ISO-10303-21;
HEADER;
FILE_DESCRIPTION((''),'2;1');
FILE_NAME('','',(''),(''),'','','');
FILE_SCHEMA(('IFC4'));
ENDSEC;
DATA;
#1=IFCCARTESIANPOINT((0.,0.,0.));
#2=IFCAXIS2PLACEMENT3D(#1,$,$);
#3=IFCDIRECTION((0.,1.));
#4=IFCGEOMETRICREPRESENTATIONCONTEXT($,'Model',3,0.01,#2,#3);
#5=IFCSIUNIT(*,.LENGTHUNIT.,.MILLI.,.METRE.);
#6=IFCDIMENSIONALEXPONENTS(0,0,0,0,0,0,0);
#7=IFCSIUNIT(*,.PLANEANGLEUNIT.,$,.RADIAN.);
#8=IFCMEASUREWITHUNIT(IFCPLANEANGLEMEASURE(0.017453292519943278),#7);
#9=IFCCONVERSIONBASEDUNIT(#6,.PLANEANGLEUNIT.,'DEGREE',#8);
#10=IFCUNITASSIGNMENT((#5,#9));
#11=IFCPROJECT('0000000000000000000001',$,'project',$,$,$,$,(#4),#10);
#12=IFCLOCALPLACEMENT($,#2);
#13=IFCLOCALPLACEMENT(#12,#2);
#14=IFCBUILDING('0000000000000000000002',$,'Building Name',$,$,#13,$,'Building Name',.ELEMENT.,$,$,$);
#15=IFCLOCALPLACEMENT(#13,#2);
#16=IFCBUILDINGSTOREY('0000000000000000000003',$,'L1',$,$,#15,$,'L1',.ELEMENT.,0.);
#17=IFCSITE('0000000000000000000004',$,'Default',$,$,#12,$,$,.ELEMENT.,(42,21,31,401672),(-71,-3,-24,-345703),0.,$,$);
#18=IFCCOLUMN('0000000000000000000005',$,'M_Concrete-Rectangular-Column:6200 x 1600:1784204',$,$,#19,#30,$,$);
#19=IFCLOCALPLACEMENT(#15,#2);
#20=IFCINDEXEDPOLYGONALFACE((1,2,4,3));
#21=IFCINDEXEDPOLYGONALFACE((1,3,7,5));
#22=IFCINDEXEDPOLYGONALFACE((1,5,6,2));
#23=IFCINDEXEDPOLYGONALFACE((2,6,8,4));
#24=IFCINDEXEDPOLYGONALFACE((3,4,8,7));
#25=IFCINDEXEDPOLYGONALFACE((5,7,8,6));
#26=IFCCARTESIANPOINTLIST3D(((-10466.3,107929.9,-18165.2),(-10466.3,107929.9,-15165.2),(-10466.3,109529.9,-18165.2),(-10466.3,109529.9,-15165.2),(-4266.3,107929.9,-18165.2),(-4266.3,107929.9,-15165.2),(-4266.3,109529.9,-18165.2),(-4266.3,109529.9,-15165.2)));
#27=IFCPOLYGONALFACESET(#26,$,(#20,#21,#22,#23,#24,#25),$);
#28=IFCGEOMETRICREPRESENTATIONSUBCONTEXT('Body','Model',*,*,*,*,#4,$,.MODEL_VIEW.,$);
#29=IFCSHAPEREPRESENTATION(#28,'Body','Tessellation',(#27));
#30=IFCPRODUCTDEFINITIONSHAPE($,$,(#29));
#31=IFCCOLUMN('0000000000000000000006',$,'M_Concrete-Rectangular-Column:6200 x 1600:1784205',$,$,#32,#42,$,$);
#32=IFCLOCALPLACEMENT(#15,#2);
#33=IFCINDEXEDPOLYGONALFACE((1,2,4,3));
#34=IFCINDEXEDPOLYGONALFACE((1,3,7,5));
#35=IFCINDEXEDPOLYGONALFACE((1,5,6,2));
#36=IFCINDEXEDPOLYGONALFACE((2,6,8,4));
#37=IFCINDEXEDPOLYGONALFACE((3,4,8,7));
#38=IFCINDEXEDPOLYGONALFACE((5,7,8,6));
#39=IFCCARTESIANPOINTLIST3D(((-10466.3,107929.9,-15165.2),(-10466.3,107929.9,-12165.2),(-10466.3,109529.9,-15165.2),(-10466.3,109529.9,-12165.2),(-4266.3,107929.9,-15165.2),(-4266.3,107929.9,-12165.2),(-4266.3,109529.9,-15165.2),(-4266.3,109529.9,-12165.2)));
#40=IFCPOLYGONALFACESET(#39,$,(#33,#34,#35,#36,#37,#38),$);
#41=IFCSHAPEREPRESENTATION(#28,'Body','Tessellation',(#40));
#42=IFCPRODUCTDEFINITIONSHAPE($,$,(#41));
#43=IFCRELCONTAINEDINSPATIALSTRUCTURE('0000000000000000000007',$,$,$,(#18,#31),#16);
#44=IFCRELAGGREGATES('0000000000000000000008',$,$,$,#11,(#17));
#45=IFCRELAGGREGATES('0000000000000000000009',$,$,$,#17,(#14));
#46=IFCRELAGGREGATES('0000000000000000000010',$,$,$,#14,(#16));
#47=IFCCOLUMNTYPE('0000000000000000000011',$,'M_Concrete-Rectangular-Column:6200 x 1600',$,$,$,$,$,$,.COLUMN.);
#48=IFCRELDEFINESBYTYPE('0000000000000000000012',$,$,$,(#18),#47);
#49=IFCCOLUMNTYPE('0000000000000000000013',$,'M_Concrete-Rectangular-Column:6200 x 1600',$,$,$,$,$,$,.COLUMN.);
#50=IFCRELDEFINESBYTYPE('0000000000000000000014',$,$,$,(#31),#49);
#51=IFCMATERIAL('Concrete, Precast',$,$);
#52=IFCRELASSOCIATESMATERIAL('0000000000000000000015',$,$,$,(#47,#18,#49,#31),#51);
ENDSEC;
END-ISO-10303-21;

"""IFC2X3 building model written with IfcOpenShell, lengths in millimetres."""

from ifc_helpers import new_model, entity, si_unit, converted_unit, direction, frame, frame_2d, origin, place, context, subcontext, project, spatial, rectangle, extrude, source, transform, mapped, material, type_object, type_shapes, element, save


model = new_model("IFC2X3")

# Units and contexts
model_context = context("Model", 3, precision=0.01, world=origin(), true_north=direction((0.0, 1.0)))
body_context = subcontext(model_context, "Body", "Model", "MODEL_VIEW")
ifc_project = project(units=[si_unit("LENGTHUNIT", "METRE", prefix="MILLI"), converted_unit("PLANEANGLEUNIT", "DEGREE", entity("IfcPlaneAngleMeasure", 0.017453292519943278), si_unit("PLANEANGLEUNIT", "RADIAN"), dimensions=[0, 0, 0, 0, 0, 0, 0])], contexts=[model_context])

# Site, building, storey
site_placement = place(None, origin())
site = spatial("IfcSite", under=ifc_project, at=site_placement, Name="Default", CompositionType="ELEMENT", RefLatitude=(42, 21, 31, 401672), RefLongitude=(-71, -3, -24, -345703), RefElevation=0.0)
building_placement = place(site_placement, origin())
building = spatial("IfcBuilding", under=site, at=building_placement, Name="Building Name", LongName="Building Name", CompositionType="ELEMENT")
storey_placement = place(building_placement, origin())
storey = spatial("IfcBuildingStorey", under=building, at=storey_placement, Name="L1", LongName="L1", CompositionType="ELEMENT", Elevation=0.0)

# Columns
ifc_material_1 = material(Name="Concrete, Precast")
column_type_1 = type_object("IfcColumnType", Name="M_Concrete-Rectangular-Column:6200 x 1600", PredefinedType="COLUMN", material=ifc_material_1)
shared_shape_1 = source(origin(), body_context, "Body", "SweptSolid", [
    extrude(rectangle(XDim=1600.0, YDim=6200.0, at=frame_2d((0.0, 0.0), x_axis=(1.0, 0.0))), frame((-7366.3, 108729.9, -18165.2), z_axis=(0.0, 0.0, 1.0), x_axis=(0.0, -1.0, 0.0)), (0.0, 0.0, 1.0), 3000.0),
])
type_shapes(column_type_1, [shared_shape_1])
column_1_placement = place(storey_placement, origin())
element("IfcColumn", 1, at=column_1_placement, inside=storey, type_object=column_type_1, material=ifc_material_1, Name="M_Concrete-Rectangular-Column:6200 x 1600:1784204", context=body_context, shape_type="MappedRepresentation", body=[
    mapped(shared_shape_1, transform((0.0, 0.0, 0.0), scale=1.0)),
])
column_type_2 = type_object("IfcColumnType", Name="M_Concrete-Rectangular-Column:6200 x 1600", PredefinedType="COLUMN", material=ifc_material_1)
shared_shape_2 = source(origin(), body_context, "Body", "SweptSolid", [
    extrude(rectangle(XDim=1600.0, YDim=6200.0, at=frame_2d((0.0, 0.0), x_axis=(1.0, 0.0))), frame((-7366.3, 108729.9, -15165.2), z_axis=(0.0, 0.0, 1.0), x_axis=(0.0, -1.0, 0.0)), (0.0, 0.0, 1.0), 3000.0),
])
type_shapes(column_type_2, [shared_shape_2])
column_2_placement = place(storey_placement, origin())
element("IfcColumn", 2, at=column_2_placement, inside=storey, type_object=column_type_2, material=ifc_material_1, Name="M_Concrete-Rectangular-Column:6200 x 1600:1784205", context=body_context, shape_type="MappedRepresentation", body=[
    mapped(shared_shape_2, transform((0.0, 0.0, 0.0), scale=1.0)),
])

save(model, "model.ifc")
